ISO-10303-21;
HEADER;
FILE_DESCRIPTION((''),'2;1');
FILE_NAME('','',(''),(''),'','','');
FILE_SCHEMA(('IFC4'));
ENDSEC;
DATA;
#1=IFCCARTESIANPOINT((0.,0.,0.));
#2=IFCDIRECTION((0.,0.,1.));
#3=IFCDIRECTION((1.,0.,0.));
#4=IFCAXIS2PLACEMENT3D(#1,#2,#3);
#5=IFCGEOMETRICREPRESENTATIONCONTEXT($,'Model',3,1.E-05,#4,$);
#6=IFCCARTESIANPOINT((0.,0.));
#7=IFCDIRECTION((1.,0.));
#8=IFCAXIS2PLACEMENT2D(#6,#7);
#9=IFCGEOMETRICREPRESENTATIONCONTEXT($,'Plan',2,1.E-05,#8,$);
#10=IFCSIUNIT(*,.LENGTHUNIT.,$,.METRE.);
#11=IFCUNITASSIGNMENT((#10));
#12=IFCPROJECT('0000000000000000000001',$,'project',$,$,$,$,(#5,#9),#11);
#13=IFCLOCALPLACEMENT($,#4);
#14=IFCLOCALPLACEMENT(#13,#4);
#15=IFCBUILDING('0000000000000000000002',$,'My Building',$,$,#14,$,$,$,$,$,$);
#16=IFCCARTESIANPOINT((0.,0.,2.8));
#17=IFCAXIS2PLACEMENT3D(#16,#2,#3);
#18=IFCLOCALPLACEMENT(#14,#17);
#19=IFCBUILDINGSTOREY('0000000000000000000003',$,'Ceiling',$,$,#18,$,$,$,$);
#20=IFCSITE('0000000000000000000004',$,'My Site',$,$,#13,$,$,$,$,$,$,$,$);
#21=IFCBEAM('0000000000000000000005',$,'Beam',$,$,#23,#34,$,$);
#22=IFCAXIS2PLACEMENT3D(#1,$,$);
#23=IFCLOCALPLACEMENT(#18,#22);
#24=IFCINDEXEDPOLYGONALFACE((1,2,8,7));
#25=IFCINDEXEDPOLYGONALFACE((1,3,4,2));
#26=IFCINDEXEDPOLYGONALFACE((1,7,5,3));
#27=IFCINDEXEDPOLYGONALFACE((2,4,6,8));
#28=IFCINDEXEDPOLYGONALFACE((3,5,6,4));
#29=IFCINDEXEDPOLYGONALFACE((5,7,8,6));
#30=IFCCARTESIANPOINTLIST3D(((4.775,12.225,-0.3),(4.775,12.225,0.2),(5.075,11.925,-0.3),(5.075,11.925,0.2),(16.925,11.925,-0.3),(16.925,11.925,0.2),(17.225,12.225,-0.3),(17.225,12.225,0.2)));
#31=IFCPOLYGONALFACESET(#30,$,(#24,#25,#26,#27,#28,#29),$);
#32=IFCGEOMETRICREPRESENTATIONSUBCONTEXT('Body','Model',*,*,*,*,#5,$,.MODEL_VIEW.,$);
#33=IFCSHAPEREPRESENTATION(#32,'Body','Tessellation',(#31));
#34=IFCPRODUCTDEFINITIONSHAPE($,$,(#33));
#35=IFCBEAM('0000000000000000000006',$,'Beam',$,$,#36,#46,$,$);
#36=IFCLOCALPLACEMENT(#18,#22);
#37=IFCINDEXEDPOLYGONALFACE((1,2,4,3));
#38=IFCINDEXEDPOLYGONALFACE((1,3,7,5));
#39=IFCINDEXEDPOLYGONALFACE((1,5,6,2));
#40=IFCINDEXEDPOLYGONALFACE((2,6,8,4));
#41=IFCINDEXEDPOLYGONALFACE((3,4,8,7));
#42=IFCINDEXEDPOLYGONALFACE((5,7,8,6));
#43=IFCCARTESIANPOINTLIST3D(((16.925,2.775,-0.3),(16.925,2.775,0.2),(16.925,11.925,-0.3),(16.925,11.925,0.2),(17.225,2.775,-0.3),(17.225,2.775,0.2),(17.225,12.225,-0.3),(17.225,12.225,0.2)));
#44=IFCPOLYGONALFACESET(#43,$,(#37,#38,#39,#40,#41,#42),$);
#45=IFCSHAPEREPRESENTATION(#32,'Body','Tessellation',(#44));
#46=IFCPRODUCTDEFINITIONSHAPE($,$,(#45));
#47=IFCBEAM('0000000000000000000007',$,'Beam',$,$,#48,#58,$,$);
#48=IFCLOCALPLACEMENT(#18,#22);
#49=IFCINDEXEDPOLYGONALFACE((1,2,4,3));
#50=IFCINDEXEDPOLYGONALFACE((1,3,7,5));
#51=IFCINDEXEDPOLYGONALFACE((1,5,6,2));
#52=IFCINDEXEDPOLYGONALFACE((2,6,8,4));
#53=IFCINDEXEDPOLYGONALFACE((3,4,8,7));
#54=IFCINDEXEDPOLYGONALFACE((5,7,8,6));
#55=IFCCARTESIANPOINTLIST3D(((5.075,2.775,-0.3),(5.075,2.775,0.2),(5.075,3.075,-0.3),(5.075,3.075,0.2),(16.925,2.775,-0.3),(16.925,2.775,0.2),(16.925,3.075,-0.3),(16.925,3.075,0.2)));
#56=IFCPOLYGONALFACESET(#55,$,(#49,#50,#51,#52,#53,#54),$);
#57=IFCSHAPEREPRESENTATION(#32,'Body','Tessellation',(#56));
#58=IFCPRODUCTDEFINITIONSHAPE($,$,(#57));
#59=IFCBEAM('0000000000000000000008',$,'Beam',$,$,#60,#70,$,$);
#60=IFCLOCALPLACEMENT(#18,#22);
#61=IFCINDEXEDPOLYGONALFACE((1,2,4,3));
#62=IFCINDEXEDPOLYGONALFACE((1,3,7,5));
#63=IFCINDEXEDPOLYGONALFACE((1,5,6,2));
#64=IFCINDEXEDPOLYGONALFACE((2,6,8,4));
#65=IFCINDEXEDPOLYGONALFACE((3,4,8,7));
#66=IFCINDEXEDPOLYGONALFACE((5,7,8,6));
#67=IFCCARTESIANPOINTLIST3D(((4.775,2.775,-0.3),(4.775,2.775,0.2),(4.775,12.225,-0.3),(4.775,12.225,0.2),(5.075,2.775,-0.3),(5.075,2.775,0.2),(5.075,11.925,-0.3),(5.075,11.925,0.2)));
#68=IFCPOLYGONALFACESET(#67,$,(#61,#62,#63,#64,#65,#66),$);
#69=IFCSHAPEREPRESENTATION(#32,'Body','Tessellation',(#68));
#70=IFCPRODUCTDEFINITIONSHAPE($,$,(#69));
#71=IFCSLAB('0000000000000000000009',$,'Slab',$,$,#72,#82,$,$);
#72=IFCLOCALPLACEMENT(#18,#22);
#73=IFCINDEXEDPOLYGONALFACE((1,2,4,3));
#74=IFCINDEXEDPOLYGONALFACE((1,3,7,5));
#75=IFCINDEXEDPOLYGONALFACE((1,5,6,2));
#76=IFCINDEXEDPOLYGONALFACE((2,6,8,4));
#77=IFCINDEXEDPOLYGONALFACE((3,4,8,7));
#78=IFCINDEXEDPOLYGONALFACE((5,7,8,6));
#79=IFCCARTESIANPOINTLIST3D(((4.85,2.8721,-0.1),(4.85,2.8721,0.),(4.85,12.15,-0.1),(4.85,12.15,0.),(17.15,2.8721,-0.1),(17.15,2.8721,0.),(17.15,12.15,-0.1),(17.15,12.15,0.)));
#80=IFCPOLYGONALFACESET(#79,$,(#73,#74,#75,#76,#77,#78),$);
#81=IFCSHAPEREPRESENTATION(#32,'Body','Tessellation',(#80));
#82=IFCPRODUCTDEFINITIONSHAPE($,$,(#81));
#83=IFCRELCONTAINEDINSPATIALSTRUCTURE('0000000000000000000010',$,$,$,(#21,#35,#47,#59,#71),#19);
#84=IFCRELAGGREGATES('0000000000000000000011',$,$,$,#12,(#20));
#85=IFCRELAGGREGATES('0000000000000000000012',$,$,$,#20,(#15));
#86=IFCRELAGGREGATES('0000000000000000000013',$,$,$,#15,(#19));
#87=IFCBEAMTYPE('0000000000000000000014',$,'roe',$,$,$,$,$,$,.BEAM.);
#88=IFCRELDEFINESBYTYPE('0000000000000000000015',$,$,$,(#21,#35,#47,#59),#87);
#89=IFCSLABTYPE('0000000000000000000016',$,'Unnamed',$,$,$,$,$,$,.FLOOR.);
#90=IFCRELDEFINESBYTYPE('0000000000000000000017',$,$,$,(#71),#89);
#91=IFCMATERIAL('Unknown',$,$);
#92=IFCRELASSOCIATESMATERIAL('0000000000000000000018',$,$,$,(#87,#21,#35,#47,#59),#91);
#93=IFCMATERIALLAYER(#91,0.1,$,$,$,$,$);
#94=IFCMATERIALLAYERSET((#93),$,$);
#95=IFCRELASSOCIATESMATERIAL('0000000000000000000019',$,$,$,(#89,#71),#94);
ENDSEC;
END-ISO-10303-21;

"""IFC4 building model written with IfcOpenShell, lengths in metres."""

from ifc_helpers import new_model, si_unit, frame, origin_with_axes, origin_2d_with_axis, place, context, subcontext, project, spatial, indexed_curve, rectangle, outline, extrude, clip, halfspace, material, layer, layer_set, layer_usage, material_profile, profile_set, profile_usage, type_object, element, save


model = new_model("IFC4")

# Units and contexts
model_context = context("Model", 3, precision=1e-05, world=origin_with_axes())
plan_context = context("Plan", 2, precision=1e-05, world=origin_2d_with_axis())
body_context = subcontext(model_context, "Body", "Model", "MODEL_VIEW")
ifc_project = project(units=[si_unit("LENGTHUNIT", "METRE")], contexts=[model_context, plan_context])

# Site, building, storey
site_placement = place(None, origin_with_axes())
site = spatial("IfcSite", under=ifc_project, at=site_placement, Name="My Site")
building_placement = place(site_placement, origin_with_axes())
building = spatial("IfcBuilding", under=site, at=building_placement, Name="My Building")
storey_placement = place(building_placement, frame((0.0, 0.0, 2.8), z_axis=(0.0, 0.0, 1.0), x_axis=(1.0, 0.0, 0.0)))
storey = spatial("IfcBuildingStorey", under=building, at=storey_placement, Name="Ceiling")

# Beams
ifc_material = material(Name="Unknown")
ifc_material_profile = material_profile(ifc_material, rectangle(XDim=0.3, YDim=0.5))
ifc_profile_set = profile_set([ifc_material_profile])
ifc_profile_usage_1 = profile_usage(ifc_profile_set, cardinal=5)
beam_type = type_object("IfcBeamType", Name="roe", PredefinedType="BEAM", material=ifc_profile_set)
beam_1_placement = place(storey_placement, frame((4.775, 12.075, -0.05), z_axis=(1.0, 0.0, 0.0), x_axis=(0.0, 1.0, 0.0)))
element("IfcBeam", 1, at=beam_1_placement, inside=storey, type_object=beam_type, material=ifc_profile_usage_1, Name="Beam", context=body_context, shape_type="Clipping", body=[
    clip(clip(extrude(rectangle(XDim=0.3, YDim=0.5), origin_with_axes(), (0.0, 0.0, 1.0), 12.45), halfspace(frame((0.15, -2.8, 12.45), z_axis=(-0.707107, 0.0, 0.707107), x_axis=(0.0, 1.0, 0.0)), False)), halfspace(frame((0.15, -2.8, 0.0), z_axis=(-0.707108, 0.0, -0.707106), x_axis=(0.0, 1.0, 0.0)), False)),
])
ifc_profile_usage_2 = profile_usage(ifc_profile_set, cardinal=5)
beam_2_placement = place(storey_placement, frame((17.075, 12.225, -0.05), z_axis=(0.0, -1.0, 0.0), x_axis=(1.0, 0.0, 0.0)))
element("IfcBeam", 2, at=beam_2_placement, inside=storey, type_object=beam_type, material=ifc_profile_usage_2, Name="Beam", context=body_context, shape_type="Clipping", body=[
    clip(extrude(rectangle(XDim=0.3, YDim=0.5), origin_with_axes(), (0.0, 0.0, 1.0), 9.45), halfspace(frame((0.15, -2.8, 0.0), z_axis=(-0.707107, 0.0, -0.707107), x_axis=(0.0, 1.0, 0.0)), False)),
])
ifc_profile_usage_3 = profile_usage(ifc_profile_set, cardinal=5)
beam_3_placement = place(storey_placement, frame((16.925, 2.925, -0.05), z_axis=(-1.0, 0.0, 0.0), x_axis=(0.0, -1.0, 0.0)))
element("IfcBeam", 3, at=beam_3_placement, inside=storey, type_object=beam_type, material=ifc_profile_usage_3, Name="Beam", context=body_context, shape_type="SweptSolid", body=[
    extrude(rectangle(XDim=0.3, YDim=0.5), origin_with_axes(), (0.0, 0.0, 1.0), 11.85),
])
ifc_profile_usage_4 = profile_usage(ifc_profile_set, cardinal=5)
beam_4_placement = place(storey_placement, frame((4.925, 2.775, -0.05), z_axis=(0.0, 1.0, 0.0), x_axis=(-1.0, 0.0, 0.0)))
element("IfcBeam", 4, at=beam_4_placement, inside=storey, type_object=beam_type, material=ifc_profile_usage_4, Name="Beam", context=body_context, shape_type="Clipping", body=[
    clip(extrude(rectangle(XDim=0.3, YDim=0.5), origin_with_axes(), (0.0, 0.0, 1.0), 9.45), halfspace(frame((0.15, -2.8, 9.45), z_axis=(-0.707106, 0.0, 0.707108), x_axis=(0.0, 1.0, 0.0)), False)),
])

# Slab
ifc_layer = layer(ifc_material, 0.1)
ifc_layer_set = layer_set([ifc_layer])
ifc_layer_usage = layer_usage(ifc_layer_set, "AXIS3", "POSITIVE", -0.1)
slab_type = type_object("IfcSlabType", Name="Unnamed", PredefinedType="FLOOR", material=ifc_layer_set)
slab_placement = place(storey_placement, frame((17.15, 12.15, 0.0), z_axis=(0.0, 0.0, 1.0), x_axis=(1.0, 0.0, 0.0)))
element("IfcSlab", 5, at=slab_placement, inside=storey, type_object=slab_type, material=ifc_layer_usage, Name="Slab", context=body_context, shape_type="SweptSolid", body=[
    extrude(outline(indexed_curve([(0.0, -9.2779), (-12.3, -9.2779), (-12.3, 0.0), (0.0, 0.0), (0.0, -9.2779)])), frame((0.0, 0.0, -0.1), z_axis=(0.0, 0.0, 1.0), x_axis=(1.0, 0.0, 0.0)), (0.0, 0.0, 1.0), 0.1),
])

save(model, "model.ifc")
